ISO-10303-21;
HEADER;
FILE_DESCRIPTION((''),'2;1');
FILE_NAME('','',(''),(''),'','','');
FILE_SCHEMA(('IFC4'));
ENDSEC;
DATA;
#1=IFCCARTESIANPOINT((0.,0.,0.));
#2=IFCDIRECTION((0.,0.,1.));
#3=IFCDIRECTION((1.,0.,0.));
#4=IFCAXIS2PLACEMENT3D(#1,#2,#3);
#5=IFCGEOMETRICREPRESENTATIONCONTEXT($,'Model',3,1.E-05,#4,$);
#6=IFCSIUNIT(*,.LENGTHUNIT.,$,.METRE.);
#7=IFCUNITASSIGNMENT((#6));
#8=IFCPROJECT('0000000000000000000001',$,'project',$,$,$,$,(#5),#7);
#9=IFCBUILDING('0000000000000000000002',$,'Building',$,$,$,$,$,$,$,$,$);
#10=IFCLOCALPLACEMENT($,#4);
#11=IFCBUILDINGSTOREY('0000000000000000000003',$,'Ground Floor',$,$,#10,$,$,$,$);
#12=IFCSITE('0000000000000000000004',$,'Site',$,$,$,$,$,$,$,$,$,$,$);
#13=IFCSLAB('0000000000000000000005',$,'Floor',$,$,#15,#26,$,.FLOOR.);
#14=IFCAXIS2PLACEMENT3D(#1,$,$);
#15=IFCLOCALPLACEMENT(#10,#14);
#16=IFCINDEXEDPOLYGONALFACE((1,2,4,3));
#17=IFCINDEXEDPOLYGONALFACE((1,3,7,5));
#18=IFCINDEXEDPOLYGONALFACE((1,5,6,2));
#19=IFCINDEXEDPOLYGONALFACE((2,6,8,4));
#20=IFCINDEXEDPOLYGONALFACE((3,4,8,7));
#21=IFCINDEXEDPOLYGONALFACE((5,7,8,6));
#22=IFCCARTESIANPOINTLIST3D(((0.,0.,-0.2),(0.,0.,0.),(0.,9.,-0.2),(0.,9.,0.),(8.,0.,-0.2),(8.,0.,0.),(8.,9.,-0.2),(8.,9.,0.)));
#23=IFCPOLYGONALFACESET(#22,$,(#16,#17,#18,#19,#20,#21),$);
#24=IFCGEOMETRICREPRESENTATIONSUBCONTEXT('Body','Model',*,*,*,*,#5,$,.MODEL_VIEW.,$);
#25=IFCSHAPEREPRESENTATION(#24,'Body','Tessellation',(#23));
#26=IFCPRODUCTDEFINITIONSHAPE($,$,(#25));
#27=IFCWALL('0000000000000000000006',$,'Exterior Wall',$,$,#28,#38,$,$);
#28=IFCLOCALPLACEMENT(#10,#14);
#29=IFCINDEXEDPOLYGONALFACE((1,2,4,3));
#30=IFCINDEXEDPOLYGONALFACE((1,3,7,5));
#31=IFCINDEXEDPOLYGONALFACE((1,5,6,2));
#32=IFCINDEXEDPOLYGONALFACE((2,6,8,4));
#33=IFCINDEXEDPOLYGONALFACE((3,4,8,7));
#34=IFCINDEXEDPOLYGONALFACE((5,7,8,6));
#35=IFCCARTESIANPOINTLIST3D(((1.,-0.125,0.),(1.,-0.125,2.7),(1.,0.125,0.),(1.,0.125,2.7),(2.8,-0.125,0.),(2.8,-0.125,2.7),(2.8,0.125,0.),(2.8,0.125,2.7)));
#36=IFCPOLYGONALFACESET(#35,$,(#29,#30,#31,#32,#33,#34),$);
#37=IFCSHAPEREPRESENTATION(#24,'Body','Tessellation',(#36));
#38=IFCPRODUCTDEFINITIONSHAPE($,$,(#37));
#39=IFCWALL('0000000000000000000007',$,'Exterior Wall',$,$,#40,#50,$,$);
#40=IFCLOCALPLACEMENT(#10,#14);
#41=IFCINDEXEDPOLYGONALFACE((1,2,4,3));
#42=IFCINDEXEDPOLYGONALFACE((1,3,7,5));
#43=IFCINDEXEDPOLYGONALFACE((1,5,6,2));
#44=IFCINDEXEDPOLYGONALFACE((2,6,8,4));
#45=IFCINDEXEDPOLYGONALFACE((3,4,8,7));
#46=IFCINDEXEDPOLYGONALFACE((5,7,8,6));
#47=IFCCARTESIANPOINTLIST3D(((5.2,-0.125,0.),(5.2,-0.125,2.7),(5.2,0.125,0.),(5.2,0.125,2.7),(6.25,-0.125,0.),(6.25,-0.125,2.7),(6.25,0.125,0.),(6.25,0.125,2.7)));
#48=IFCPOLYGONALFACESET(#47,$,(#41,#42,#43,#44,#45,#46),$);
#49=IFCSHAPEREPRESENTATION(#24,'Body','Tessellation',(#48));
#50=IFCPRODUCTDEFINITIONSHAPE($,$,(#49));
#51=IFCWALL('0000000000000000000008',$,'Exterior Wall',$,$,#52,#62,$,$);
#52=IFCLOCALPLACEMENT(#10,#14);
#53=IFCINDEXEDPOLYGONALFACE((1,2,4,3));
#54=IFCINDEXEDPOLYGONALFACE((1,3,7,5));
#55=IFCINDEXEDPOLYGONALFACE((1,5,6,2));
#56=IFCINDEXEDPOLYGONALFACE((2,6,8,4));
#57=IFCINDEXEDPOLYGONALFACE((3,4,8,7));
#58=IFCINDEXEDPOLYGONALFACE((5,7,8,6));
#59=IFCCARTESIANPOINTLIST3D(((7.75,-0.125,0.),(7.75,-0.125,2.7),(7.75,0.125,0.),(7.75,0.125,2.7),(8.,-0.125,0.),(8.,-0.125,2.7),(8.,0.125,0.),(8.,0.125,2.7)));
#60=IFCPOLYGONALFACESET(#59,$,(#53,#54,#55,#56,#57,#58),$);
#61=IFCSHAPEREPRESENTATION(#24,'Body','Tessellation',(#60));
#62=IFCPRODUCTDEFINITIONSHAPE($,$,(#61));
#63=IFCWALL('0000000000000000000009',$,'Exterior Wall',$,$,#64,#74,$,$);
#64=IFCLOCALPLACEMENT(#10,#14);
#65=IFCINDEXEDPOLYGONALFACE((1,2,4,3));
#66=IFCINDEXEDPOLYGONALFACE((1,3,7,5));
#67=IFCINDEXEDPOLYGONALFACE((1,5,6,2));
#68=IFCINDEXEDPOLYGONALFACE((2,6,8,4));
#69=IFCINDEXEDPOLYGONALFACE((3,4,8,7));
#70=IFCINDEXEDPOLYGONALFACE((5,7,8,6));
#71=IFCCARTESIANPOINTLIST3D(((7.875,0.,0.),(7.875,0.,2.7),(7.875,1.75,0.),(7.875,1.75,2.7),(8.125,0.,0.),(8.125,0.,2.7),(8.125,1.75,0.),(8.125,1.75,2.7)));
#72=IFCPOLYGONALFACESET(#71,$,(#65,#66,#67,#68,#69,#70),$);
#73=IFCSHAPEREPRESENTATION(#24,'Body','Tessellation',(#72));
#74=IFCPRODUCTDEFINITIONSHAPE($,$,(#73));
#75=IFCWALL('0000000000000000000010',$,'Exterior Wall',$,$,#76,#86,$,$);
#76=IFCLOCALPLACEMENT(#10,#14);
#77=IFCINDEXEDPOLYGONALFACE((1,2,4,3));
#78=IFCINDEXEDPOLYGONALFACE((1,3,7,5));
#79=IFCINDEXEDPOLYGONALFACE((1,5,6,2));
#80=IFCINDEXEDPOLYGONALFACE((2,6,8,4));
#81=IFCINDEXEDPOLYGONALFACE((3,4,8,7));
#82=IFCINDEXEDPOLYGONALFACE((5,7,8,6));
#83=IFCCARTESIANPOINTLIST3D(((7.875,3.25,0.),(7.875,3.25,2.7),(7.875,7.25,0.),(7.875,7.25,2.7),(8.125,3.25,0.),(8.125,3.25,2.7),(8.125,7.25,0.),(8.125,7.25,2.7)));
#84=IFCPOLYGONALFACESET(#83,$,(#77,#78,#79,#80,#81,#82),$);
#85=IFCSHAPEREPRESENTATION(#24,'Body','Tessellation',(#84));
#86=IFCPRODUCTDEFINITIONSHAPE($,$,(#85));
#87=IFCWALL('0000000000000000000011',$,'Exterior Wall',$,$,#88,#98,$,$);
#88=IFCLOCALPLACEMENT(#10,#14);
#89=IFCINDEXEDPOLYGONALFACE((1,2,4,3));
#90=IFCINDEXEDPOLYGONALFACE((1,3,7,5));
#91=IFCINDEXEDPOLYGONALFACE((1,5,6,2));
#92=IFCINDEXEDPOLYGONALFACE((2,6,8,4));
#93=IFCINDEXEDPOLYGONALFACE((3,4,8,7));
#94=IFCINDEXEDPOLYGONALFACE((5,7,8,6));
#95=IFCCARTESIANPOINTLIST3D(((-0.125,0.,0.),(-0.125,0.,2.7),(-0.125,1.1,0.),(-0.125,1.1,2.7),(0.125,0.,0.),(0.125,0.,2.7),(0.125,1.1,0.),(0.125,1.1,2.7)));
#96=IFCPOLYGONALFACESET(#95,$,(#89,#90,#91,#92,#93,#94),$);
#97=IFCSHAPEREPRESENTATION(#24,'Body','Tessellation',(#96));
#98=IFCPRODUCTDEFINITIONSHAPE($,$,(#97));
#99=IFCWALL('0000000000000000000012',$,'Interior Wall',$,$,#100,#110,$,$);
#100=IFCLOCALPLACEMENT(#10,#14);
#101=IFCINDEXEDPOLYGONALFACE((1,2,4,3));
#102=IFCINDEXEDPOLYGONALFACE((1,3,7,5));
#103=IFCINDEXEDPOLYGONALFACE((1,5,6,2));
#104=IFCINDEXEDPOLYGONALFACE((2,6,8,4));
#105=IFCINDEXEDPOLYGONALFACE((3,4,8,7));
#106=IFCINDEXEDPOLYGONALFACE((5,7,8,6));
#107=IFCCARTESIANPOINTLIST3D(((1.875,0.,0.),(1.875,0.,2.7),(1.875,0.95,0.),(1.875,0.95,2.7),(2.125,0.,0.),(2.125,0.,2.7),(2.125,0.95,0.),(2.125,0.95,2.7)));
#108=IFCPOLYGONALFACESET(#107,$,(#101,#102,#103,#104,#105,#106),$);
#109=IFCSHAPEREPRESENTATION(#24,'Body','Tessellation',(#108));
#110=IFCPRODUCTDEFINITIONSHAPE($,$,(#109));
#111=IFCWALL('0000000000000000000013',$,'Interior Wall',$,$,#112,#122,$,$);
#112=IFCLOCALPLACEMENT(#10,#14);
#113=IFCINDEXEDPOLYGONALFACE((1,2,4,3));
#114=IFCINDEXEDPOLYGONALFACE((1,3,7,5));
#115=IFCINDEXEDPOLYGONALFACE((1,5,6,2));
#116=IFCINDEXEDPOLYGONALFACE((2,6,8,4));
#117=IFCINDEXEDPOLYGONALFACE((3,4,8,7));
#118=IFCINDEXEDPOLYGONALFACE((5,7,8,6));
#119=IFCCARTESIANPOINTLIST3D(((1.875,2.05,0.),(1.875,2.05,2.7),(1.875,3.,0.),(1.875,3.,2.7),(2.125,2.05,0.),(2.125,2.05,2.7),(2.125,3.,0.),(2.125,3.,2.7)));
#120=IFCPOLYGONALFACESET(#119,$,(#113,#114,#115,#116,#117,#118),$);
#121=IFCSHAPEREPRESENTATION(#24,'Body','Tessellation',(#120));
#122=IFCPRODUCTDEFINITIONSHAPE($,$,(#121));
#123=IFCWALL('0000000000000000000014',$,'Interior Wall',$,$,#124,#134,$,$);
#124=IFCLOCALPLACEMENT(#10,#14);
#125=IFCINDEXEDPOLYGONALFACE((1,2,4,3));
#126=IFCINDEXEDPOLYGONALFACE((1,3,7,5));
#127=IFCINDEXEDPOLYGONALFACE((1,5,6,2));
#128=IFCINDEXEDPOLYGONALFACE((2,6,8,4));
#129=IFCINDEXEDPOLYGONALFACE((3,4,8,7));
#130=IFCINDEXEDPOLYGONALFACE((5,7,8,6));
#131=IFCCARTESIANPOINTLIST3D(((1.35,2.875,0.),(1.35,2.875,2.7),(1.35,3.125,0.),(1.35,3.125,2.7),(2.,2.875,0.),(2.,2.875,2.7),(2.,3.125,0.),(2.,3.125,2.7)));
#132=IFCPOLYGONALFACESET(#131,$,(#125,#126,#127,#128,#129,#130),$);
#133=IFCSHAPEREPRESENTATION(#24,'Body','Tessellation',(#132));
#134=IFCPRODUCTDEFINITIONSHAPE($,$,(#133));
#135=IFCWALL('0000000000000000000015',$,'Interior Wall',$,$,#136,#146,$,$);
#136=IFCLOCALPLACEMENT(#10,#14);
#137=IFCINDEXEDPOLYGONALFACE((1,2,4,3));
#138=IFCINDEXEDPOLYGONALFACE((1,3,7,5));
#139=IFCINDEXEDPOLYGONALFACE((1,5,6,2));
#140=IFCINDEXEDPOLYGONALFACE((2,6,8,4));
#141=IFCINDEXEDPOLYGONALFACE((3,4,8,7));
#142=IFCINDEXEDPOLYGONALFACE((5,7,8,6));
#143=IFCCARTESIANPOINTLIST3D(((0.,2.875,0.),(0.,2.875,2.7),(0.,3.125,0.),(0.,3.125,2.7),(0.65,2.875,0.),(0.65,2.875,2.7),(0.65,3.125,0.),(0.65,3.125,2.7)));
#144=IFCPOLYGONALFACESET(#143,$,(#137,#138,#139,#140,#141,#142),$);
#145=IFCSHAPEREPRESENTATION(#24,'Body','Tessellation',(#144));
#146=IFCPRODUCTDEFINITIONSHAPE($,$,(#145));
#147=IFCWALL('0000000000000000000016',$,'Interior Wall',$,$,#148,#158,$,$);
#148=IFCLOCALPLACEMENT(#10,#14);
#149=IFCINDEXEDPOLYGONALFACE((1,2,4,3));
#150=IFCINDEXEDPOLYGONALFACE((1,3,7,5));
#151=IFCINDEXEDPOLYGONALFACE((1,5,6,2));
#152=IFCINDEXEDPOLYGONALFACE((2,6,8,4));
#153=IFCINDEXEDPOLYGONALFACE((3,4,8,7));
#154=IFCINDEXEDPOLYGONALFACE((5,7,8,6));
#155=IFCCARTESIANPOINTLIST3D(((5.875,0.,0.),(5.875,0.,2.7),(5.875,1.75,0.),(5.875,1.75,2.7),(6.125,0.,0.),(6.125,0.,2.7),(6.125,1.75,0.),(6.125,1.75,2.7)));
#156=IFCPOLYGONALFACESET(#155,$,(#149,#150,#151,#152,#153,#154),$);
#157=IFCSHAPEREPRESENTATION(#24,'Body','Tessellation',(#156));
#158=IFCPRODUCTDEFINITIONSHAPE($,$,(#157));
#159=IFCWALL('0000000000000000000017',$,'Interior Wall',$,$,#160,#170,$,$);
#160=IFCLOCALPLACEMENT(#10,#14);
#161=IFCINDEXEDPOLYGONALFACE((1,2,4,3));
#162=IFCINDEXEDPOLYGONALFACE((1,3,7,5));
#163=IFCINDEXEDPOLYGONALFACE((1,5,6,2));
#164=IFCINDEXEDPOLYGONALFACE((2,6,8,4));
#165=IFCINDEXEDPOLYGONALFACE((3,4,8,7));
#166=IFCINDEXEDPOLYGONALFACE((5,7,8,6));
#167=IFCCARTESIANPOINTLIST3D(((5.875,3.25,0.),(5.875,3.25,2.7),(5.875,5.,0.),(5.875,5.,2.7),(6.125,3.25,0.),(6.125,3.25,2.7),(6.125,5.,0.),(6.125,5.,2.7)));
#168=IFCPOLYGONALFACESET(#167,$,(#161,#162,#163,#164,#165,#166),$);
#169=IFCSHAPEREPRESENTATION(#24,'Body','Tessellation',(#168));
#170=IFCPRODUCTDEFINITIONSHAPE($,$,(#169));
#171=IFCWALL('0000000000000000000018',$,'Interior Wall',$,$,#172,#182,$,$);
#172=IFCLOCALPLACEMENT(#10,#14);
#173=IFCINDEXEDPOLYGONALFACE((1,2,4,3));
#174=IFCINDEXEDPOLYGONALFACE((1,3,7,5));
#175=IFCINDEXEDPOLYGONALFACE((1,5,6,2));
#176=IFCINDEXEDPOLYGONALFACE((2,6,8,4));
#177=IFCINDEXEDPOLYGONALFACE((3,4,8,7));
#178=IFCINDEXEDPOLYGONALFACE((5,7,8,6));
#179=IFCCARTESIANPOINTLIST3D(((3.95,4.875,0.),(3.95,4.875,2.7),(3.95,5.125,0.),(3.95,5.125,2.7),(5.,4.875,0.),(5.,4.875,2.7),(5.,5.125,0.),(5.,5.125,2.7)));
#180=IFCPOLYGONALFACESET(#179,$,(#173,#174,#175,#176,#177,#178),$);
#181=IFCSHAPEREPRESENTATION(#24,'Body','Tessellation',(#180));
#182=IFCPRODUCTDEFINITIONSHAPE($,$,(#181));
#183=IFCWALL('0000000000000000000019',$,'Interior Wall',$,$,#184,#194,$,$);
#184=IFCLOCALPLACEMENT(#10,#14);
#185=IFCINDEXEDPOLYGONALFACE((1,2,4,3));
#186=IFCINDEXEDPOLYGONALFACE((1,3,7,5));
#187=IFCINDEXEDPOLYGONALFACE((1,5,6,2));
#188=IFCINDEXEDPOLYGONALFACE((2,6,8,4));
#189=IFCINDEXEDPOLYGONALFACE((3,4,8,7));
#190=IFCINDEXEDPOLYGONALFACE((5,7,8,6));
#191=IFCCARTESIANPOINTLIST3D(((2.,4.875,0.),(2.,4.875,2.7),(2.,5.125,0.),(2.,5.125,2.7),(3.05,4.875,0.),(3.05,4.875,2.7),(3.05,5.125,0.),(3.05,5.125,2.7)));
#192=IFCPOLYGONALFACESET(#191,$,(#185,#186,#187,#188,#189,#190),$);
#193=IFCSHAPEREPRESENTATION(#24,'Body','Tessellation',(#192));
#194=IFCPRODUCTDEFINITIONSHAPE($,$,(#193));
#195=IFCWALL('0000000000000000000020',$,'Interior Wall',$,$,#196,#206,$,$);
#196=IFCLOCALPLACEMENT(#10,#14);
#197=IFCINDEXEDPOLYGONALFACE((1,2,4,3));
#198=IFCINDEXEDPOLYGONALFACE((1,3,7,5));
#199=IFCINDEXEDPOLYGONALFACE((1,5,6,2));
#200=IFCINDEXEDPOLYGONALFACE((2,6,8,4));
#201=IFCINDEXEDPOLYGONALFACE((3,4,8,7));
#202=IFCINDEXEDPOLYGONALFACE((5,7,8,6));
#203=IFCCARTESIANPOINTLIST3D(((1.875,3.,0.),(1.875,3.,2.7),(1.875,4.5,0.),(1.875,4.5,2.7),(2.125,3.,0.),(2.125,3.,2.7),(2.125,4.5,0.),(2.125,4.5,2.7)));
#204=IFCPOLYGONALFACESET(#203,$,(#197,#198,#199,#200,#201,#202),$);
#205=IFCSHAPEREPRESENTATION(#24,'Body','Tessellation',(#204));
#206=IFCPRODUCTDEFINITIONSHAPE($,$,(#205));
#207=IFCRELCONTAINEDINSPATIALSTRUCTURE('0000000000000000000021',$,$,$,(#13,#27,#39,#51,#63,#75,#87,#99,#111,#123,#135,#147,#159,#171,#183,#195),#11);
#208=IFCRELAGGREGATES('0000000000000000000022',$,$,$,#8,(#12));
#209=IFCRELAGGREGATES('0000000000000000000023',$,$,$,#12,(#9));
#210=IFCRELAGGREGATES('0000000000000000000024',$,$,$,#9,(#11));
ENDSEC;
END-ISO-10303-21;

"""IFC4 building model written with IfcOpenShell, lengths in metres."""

from ifc_helpers import new_model, si_unit, frame, origin_with_axes, place, context, subcontext, project, spatial, indexed_curve, outline, extrude, element, save


model = new_model("IFC4")

# Units and contexts
model_context = context("Model", 3, precision=1e-05, world=origin_with_axes())
body_context = subcontext(model_context, "Body", "Model", "MODEL_VIEW")
ifc_project = project(units=[si_unit("LENGTHUNIT", "METRE")], contexts=[model_context])

# Site, building, storey
site = spatial("IfcSite", under=ifc_project, Name="Site")
building = spatial("IfcBuilding", under=site, Name="Building")
storey_placement = place(None, origin_with_axes())
storey = spatial("IfcBuildingStorey", under=building, at=storey_placement, Name="Ground Floor")

# Slab
slab_placement = place(storey_placement, frame((0.0, 0.0, -0.2), z_axis=(0.0, 0.0, 1.0), x_axis=(1.0, 0.0, 0.0)))
element("IfcSlab", 1, at=slab_placement, inside=storey, Name="Floor", PredefinedType="FLOOR", context=body_context, shape_type="SweptSolid", body=[
    extrude(outline(indexed_curve([(0.0, 0.0), (8.0, 0.0), (8.0, 9.0), (0.0, 9.0)])), None, (0.0, 0.0, 1.0), 0.2),
])

# Walls
wall_1_placement = place(storey_placement, frame((1.0, 0.0, 0.0), z_axis=(0.0, 0.0, 1.0), x_axis=(1.0, 0.0, 0.0)))
element("IfcWall", 2, at=wall_1_placement, inside=storey, Name="Exterior Wall", context=body_context, shape_type="SweptSolid", body=[
    extrude(outline(indexed_curve([(0.0, 0.0), (0.0, 0.25), (1.8, 0.25), (1.8, 0.0), (0.0, 0.0)], self_intersect=False)), frame((0.0, -0.125, 0.0), z_axis=(0.0, 0.0, 1.0), x_axis=(1.0, 0.0, 0.0)), (0.0, 0.0, 1.0), 2.7),
])
wall_2_placement = place(storey_placement, frame((5.2, 0.0, 0.0), z_axis=(0.0, 0.0, 1.0), x_axis=(1.0, 0.0, 0.0)))
element("IfcWall", 3, at=wall_2_placement, inside=storey, Name="Exterior Wall", context=body_context, shape_type="SweptSolid", body=[
    extrude(outline(indexed_curve([(0.0, 0.0), (0.0, 0.25), (1.05, 0.25), (1.05, 0.0), (0.0, 0.0)], self_intersect=False)), frame((0.0, -0.125, 0.0), z_axis=(0.0, 0.0, 1.0), x_axis=(1.0, 0.0, 0.0)), (0.0, 0.0, 1.0), 2.7),
])
wall_3_placement = place(storey_placement, frame((7.75, 0.0, 0.0), z_axis=(0.0, 0.0, 1.0), x_axis=(1.0, 0.0, 0.0)))
element("IfcWall", 4, at=wall_3_placement, inside=storey, Name="Exterior Wall", context=body_context, shape_type="SweptSolid", body=[
    extrude(outline(indexed_curve([(0.0, 0.0), (0.0, 0.25), (0.25, 0.25), (0.25, 0.0), (0.0, 0.0)], self_intersect=False)), frame((0.0, -0.125, 0.0), z_axis=(0.0, 0.0, 1.0), x_axis=(1.0, 0.0, 0.0)), (0.0, 0.0, 1.0), 2.7),
])
wall_4_placement = place(storey_placement, frame((8.0, 0.0, 0.0), z_axis=(0.0, 0.0, 1.0), x_axis=(0.0, 1.0, 0.0)))
element("IfcWall", 5, at=wall_4_placement, inside=storey, Name="Exterior Wall", context=body_context, shape_type="SweptSolid", body=[
    extrude(outline(indexed_curve([(0.0, 0.0), (0.0, 0.25), (1.75, 0.25), (1.75, 0.0), (0.0, 0.0)], self_intersect=False)), frame((0.0, -0.125, 0.0), z_axis=(0.0, 0.0, 1.0), x_axis=(1.0, 0.0, 0.0)), (0.0, 0.0, 1.0), 2.7),
])
wall_5_placement = place(storey_placement, frame((8.0, 3.25, 0.0), z_axis=(0.0, 0.0, 1.0), x_axis=(0.0, 1.0, 0.0)))
element("IfcWall", 6, at=wall_5_placement, inside=storey, Name="Exterior Wall", context=body_context, shape_type="SweptSolid", body=[
    extrude(outline(indexed_curve([(0.0, 0.0), (0.0, 0.25), (4.0, 0.25), (4.0, 0.0), (0.0, 0.0)], self_intersect=False)), frame((0.0, -0.125, 0.0), z_axis=(0.0, 0.0, 1.0), x_axis=(1.0, 0.0, 0.0)), (0.0, 0.0, 1.0), 2.7),
])
wall_6_placement = place(storey_placement, frame((0.0, 1.1, 0.0), z_axis=(0.0, 0.0, 1.0), x_axis=(0.0, -1.0, 0.0)))
element("IfcWall", 7, at=wall_6_placement, inside=storey, Name="Exterior Wall", context=body_context, shape_type="SweptSolid", body=[
    extrude(outline(indexed_curve([(0.0, 0.0), (0.0, 0.25), (1.1, 0.25), (1.1, 0.0), (0.0, 0.0)], self_intersect=False)), frame((0.0, -0.125, 0.0), z_axis=(0.0, 0.0, 1.0), x_axis=(1.0, 0.0, 0.0)), (0.0, 0.0, 1.0), 2.7),
])
wall_7_placement = place(storey_placement, frame((2.0, 0.0, 0.0), z_axis=(0.0, 0.0, 1.0), x_axis=(0.0, 1.0, 0.0)))
element("IfcWall", 8, at=wall_7_placement, inside=storey, Name="Interior Wall", context=body_context, shape_type="SweptSolid", body=[
    extrude(outline(indexed_curve([(0.0, 0.0), (0.0, 0.25), (0.95, 0.25), (0.95, 0.0), (0.0, 0.0)], self_intersect=False)), frame((0.0, -0.125, 0.0), z_axis=(0.0, 0.0, 1.0), x_axis=(1.0, 0.0, 0.0)), (0.0, 0.0, 1.0), 2.7),
])
wall_8_placement = place(storey_placement, frame((2.0, 2.05, 0.0), z_axis=(0.0, 0.0, 1.0), x_axis=(0.0, 1.0, 0.0)))
element("IfcWall", 9, at=wall_8_placement, inside=storey, Name="Interior Wall", context=body_context, shape_type="SweptSolid", body=[
    extrude(outline(indexed_curve([(0.0, 0.0), (0.0, 0.25), (0.95, 0.25), (0.95, 0.0), (0.0, 0.0)], self_intersect=False)), frame((0.0, -0.125, 0.0), z_axis=(0.0, 0.0, 1.0), x_axis=(1.0, 0.0, 0.0)), (0.0, 0.0, 1.0), 2.7),
])
for number, where, z_axis, x_axis, name in (
    (10, (2.0, 3.0, 0.0), (0.0, 0.0, 1.0), (-1.0, 0.0, 0.0), "Interior Wall"),
    (11, (0.65, 3.0, 0.0), (0.0, 0.0, 1.0), (-1.0, 0.0, 0.0), "Interior Wall"),
):
    element("IfcWall", number, at=place(storey_placement, frame(where, z_axis=z_axis, x_axis=x_axis)), inside=storey, Name=name, context=body_context, shape_type="SweptSolid", body=[
        extrude(outline(indexed_curve([(0.0, 0.0), (0.0, 0.25), (0.65, 0.25), (0.65, 0.0), (0.0, 0.0)], self_intersect=False)), frame((0.0, -0.125, 0.0), z_axis=(0.0, 0.0, 1.0), x_axis=(1.0, 0.0, 0.0)), (0.0, 0.0, 1.0), 2.7),
    ])
for number, where, z_axis, x_axis, name in (
    (12, (6.0, 0.0, 0.0), (0.0, 0.0, 1.0), (0.0, 1.0, 0.0), "Interior Wall"),
    (13, (6.0, 3.25, 0.0), (0.0, 0.0, 1.0), (0.0, 1.0, 0.0), "Interior Wall"),
):
    element("IfcWall", number, at=place(storey_placement, frame(where, z_axis=z_axis, x_axis=x_axis)), inside=storey, Name=name, context=body_context, shape_type="SweptSolid", body=[
        extrude(outline(indexed_curve([(0.0, 0.0), (0.0, 0.25), (1.75, 0.25), (1.75, 0.0), (0.0, 0.0)], self_intersect=False)), frame((0.0, -0.125, 0.0), z_axis=(0.0, 0.0, 1.0), x_axis=(1.0, 0.0, 0.0)), (0.0, 0.0, 1.0), 2.7),
    ])
for number, where, z_axis, x_axis, name in (
    (14, (5.0, 5.0, 0.0), (0.0, 0.0, 1.0), (-1.0, 0.0, 0.0), "Interior Wall"),
    (15, (3.05, 5.0, 0.0), (0.0, 0.0, 1.0), (-1.0, 0.0, 0.0), "Interior Wall"),
):
    element("IfcWall", number, at=place(storey_placement, frame(where, z_axis=z_axis, x_axis=x_axis)), inside=storey, Name=name, context=body_context, shape_type="SweptSolid", body=[
        extrude(outline(indexed_curve([(0.0, 0.0), (0.0, 0.25), (1.05, 0.25), (1.05, 0.0), (0.0, 0.0)], self_intersect=False)), frame((0.0, -0.125, 0.0), z_axis=(0.0, 0.0, 1.0), x_axis=(1.0, 0.0, 0.0)), (0.0, 0.0, 1.0), 2.7),
    ])
wall_9_placement = place(storey_placement, frame((2.0, 4.5, 0.0), z_axis=(0.0, 0.0, 1.0), x_axis=(0.0, -1.0, 0.0)))
element("IfcWall", 16, at=wall_9_placement, inside=storey, Name="Interior Wall", context=body_context, shape_type="SweptSolid", body=[
    extrude(outline(indexed_curve([(0.0, 0.0), (0.0, 0.25), (1.5, 0.25), (1.5, 0.0), (0.0, 0.0)], self_intersect=False)), frame((0.0, -0.125, 0.0), z_axis=(0.0, 0.0, 1.0), x_axis=(1.0, 0.0, 0.0)), (0.0, 0.0, 1.0), 2.7),
])

save(model, "model.ifc")
